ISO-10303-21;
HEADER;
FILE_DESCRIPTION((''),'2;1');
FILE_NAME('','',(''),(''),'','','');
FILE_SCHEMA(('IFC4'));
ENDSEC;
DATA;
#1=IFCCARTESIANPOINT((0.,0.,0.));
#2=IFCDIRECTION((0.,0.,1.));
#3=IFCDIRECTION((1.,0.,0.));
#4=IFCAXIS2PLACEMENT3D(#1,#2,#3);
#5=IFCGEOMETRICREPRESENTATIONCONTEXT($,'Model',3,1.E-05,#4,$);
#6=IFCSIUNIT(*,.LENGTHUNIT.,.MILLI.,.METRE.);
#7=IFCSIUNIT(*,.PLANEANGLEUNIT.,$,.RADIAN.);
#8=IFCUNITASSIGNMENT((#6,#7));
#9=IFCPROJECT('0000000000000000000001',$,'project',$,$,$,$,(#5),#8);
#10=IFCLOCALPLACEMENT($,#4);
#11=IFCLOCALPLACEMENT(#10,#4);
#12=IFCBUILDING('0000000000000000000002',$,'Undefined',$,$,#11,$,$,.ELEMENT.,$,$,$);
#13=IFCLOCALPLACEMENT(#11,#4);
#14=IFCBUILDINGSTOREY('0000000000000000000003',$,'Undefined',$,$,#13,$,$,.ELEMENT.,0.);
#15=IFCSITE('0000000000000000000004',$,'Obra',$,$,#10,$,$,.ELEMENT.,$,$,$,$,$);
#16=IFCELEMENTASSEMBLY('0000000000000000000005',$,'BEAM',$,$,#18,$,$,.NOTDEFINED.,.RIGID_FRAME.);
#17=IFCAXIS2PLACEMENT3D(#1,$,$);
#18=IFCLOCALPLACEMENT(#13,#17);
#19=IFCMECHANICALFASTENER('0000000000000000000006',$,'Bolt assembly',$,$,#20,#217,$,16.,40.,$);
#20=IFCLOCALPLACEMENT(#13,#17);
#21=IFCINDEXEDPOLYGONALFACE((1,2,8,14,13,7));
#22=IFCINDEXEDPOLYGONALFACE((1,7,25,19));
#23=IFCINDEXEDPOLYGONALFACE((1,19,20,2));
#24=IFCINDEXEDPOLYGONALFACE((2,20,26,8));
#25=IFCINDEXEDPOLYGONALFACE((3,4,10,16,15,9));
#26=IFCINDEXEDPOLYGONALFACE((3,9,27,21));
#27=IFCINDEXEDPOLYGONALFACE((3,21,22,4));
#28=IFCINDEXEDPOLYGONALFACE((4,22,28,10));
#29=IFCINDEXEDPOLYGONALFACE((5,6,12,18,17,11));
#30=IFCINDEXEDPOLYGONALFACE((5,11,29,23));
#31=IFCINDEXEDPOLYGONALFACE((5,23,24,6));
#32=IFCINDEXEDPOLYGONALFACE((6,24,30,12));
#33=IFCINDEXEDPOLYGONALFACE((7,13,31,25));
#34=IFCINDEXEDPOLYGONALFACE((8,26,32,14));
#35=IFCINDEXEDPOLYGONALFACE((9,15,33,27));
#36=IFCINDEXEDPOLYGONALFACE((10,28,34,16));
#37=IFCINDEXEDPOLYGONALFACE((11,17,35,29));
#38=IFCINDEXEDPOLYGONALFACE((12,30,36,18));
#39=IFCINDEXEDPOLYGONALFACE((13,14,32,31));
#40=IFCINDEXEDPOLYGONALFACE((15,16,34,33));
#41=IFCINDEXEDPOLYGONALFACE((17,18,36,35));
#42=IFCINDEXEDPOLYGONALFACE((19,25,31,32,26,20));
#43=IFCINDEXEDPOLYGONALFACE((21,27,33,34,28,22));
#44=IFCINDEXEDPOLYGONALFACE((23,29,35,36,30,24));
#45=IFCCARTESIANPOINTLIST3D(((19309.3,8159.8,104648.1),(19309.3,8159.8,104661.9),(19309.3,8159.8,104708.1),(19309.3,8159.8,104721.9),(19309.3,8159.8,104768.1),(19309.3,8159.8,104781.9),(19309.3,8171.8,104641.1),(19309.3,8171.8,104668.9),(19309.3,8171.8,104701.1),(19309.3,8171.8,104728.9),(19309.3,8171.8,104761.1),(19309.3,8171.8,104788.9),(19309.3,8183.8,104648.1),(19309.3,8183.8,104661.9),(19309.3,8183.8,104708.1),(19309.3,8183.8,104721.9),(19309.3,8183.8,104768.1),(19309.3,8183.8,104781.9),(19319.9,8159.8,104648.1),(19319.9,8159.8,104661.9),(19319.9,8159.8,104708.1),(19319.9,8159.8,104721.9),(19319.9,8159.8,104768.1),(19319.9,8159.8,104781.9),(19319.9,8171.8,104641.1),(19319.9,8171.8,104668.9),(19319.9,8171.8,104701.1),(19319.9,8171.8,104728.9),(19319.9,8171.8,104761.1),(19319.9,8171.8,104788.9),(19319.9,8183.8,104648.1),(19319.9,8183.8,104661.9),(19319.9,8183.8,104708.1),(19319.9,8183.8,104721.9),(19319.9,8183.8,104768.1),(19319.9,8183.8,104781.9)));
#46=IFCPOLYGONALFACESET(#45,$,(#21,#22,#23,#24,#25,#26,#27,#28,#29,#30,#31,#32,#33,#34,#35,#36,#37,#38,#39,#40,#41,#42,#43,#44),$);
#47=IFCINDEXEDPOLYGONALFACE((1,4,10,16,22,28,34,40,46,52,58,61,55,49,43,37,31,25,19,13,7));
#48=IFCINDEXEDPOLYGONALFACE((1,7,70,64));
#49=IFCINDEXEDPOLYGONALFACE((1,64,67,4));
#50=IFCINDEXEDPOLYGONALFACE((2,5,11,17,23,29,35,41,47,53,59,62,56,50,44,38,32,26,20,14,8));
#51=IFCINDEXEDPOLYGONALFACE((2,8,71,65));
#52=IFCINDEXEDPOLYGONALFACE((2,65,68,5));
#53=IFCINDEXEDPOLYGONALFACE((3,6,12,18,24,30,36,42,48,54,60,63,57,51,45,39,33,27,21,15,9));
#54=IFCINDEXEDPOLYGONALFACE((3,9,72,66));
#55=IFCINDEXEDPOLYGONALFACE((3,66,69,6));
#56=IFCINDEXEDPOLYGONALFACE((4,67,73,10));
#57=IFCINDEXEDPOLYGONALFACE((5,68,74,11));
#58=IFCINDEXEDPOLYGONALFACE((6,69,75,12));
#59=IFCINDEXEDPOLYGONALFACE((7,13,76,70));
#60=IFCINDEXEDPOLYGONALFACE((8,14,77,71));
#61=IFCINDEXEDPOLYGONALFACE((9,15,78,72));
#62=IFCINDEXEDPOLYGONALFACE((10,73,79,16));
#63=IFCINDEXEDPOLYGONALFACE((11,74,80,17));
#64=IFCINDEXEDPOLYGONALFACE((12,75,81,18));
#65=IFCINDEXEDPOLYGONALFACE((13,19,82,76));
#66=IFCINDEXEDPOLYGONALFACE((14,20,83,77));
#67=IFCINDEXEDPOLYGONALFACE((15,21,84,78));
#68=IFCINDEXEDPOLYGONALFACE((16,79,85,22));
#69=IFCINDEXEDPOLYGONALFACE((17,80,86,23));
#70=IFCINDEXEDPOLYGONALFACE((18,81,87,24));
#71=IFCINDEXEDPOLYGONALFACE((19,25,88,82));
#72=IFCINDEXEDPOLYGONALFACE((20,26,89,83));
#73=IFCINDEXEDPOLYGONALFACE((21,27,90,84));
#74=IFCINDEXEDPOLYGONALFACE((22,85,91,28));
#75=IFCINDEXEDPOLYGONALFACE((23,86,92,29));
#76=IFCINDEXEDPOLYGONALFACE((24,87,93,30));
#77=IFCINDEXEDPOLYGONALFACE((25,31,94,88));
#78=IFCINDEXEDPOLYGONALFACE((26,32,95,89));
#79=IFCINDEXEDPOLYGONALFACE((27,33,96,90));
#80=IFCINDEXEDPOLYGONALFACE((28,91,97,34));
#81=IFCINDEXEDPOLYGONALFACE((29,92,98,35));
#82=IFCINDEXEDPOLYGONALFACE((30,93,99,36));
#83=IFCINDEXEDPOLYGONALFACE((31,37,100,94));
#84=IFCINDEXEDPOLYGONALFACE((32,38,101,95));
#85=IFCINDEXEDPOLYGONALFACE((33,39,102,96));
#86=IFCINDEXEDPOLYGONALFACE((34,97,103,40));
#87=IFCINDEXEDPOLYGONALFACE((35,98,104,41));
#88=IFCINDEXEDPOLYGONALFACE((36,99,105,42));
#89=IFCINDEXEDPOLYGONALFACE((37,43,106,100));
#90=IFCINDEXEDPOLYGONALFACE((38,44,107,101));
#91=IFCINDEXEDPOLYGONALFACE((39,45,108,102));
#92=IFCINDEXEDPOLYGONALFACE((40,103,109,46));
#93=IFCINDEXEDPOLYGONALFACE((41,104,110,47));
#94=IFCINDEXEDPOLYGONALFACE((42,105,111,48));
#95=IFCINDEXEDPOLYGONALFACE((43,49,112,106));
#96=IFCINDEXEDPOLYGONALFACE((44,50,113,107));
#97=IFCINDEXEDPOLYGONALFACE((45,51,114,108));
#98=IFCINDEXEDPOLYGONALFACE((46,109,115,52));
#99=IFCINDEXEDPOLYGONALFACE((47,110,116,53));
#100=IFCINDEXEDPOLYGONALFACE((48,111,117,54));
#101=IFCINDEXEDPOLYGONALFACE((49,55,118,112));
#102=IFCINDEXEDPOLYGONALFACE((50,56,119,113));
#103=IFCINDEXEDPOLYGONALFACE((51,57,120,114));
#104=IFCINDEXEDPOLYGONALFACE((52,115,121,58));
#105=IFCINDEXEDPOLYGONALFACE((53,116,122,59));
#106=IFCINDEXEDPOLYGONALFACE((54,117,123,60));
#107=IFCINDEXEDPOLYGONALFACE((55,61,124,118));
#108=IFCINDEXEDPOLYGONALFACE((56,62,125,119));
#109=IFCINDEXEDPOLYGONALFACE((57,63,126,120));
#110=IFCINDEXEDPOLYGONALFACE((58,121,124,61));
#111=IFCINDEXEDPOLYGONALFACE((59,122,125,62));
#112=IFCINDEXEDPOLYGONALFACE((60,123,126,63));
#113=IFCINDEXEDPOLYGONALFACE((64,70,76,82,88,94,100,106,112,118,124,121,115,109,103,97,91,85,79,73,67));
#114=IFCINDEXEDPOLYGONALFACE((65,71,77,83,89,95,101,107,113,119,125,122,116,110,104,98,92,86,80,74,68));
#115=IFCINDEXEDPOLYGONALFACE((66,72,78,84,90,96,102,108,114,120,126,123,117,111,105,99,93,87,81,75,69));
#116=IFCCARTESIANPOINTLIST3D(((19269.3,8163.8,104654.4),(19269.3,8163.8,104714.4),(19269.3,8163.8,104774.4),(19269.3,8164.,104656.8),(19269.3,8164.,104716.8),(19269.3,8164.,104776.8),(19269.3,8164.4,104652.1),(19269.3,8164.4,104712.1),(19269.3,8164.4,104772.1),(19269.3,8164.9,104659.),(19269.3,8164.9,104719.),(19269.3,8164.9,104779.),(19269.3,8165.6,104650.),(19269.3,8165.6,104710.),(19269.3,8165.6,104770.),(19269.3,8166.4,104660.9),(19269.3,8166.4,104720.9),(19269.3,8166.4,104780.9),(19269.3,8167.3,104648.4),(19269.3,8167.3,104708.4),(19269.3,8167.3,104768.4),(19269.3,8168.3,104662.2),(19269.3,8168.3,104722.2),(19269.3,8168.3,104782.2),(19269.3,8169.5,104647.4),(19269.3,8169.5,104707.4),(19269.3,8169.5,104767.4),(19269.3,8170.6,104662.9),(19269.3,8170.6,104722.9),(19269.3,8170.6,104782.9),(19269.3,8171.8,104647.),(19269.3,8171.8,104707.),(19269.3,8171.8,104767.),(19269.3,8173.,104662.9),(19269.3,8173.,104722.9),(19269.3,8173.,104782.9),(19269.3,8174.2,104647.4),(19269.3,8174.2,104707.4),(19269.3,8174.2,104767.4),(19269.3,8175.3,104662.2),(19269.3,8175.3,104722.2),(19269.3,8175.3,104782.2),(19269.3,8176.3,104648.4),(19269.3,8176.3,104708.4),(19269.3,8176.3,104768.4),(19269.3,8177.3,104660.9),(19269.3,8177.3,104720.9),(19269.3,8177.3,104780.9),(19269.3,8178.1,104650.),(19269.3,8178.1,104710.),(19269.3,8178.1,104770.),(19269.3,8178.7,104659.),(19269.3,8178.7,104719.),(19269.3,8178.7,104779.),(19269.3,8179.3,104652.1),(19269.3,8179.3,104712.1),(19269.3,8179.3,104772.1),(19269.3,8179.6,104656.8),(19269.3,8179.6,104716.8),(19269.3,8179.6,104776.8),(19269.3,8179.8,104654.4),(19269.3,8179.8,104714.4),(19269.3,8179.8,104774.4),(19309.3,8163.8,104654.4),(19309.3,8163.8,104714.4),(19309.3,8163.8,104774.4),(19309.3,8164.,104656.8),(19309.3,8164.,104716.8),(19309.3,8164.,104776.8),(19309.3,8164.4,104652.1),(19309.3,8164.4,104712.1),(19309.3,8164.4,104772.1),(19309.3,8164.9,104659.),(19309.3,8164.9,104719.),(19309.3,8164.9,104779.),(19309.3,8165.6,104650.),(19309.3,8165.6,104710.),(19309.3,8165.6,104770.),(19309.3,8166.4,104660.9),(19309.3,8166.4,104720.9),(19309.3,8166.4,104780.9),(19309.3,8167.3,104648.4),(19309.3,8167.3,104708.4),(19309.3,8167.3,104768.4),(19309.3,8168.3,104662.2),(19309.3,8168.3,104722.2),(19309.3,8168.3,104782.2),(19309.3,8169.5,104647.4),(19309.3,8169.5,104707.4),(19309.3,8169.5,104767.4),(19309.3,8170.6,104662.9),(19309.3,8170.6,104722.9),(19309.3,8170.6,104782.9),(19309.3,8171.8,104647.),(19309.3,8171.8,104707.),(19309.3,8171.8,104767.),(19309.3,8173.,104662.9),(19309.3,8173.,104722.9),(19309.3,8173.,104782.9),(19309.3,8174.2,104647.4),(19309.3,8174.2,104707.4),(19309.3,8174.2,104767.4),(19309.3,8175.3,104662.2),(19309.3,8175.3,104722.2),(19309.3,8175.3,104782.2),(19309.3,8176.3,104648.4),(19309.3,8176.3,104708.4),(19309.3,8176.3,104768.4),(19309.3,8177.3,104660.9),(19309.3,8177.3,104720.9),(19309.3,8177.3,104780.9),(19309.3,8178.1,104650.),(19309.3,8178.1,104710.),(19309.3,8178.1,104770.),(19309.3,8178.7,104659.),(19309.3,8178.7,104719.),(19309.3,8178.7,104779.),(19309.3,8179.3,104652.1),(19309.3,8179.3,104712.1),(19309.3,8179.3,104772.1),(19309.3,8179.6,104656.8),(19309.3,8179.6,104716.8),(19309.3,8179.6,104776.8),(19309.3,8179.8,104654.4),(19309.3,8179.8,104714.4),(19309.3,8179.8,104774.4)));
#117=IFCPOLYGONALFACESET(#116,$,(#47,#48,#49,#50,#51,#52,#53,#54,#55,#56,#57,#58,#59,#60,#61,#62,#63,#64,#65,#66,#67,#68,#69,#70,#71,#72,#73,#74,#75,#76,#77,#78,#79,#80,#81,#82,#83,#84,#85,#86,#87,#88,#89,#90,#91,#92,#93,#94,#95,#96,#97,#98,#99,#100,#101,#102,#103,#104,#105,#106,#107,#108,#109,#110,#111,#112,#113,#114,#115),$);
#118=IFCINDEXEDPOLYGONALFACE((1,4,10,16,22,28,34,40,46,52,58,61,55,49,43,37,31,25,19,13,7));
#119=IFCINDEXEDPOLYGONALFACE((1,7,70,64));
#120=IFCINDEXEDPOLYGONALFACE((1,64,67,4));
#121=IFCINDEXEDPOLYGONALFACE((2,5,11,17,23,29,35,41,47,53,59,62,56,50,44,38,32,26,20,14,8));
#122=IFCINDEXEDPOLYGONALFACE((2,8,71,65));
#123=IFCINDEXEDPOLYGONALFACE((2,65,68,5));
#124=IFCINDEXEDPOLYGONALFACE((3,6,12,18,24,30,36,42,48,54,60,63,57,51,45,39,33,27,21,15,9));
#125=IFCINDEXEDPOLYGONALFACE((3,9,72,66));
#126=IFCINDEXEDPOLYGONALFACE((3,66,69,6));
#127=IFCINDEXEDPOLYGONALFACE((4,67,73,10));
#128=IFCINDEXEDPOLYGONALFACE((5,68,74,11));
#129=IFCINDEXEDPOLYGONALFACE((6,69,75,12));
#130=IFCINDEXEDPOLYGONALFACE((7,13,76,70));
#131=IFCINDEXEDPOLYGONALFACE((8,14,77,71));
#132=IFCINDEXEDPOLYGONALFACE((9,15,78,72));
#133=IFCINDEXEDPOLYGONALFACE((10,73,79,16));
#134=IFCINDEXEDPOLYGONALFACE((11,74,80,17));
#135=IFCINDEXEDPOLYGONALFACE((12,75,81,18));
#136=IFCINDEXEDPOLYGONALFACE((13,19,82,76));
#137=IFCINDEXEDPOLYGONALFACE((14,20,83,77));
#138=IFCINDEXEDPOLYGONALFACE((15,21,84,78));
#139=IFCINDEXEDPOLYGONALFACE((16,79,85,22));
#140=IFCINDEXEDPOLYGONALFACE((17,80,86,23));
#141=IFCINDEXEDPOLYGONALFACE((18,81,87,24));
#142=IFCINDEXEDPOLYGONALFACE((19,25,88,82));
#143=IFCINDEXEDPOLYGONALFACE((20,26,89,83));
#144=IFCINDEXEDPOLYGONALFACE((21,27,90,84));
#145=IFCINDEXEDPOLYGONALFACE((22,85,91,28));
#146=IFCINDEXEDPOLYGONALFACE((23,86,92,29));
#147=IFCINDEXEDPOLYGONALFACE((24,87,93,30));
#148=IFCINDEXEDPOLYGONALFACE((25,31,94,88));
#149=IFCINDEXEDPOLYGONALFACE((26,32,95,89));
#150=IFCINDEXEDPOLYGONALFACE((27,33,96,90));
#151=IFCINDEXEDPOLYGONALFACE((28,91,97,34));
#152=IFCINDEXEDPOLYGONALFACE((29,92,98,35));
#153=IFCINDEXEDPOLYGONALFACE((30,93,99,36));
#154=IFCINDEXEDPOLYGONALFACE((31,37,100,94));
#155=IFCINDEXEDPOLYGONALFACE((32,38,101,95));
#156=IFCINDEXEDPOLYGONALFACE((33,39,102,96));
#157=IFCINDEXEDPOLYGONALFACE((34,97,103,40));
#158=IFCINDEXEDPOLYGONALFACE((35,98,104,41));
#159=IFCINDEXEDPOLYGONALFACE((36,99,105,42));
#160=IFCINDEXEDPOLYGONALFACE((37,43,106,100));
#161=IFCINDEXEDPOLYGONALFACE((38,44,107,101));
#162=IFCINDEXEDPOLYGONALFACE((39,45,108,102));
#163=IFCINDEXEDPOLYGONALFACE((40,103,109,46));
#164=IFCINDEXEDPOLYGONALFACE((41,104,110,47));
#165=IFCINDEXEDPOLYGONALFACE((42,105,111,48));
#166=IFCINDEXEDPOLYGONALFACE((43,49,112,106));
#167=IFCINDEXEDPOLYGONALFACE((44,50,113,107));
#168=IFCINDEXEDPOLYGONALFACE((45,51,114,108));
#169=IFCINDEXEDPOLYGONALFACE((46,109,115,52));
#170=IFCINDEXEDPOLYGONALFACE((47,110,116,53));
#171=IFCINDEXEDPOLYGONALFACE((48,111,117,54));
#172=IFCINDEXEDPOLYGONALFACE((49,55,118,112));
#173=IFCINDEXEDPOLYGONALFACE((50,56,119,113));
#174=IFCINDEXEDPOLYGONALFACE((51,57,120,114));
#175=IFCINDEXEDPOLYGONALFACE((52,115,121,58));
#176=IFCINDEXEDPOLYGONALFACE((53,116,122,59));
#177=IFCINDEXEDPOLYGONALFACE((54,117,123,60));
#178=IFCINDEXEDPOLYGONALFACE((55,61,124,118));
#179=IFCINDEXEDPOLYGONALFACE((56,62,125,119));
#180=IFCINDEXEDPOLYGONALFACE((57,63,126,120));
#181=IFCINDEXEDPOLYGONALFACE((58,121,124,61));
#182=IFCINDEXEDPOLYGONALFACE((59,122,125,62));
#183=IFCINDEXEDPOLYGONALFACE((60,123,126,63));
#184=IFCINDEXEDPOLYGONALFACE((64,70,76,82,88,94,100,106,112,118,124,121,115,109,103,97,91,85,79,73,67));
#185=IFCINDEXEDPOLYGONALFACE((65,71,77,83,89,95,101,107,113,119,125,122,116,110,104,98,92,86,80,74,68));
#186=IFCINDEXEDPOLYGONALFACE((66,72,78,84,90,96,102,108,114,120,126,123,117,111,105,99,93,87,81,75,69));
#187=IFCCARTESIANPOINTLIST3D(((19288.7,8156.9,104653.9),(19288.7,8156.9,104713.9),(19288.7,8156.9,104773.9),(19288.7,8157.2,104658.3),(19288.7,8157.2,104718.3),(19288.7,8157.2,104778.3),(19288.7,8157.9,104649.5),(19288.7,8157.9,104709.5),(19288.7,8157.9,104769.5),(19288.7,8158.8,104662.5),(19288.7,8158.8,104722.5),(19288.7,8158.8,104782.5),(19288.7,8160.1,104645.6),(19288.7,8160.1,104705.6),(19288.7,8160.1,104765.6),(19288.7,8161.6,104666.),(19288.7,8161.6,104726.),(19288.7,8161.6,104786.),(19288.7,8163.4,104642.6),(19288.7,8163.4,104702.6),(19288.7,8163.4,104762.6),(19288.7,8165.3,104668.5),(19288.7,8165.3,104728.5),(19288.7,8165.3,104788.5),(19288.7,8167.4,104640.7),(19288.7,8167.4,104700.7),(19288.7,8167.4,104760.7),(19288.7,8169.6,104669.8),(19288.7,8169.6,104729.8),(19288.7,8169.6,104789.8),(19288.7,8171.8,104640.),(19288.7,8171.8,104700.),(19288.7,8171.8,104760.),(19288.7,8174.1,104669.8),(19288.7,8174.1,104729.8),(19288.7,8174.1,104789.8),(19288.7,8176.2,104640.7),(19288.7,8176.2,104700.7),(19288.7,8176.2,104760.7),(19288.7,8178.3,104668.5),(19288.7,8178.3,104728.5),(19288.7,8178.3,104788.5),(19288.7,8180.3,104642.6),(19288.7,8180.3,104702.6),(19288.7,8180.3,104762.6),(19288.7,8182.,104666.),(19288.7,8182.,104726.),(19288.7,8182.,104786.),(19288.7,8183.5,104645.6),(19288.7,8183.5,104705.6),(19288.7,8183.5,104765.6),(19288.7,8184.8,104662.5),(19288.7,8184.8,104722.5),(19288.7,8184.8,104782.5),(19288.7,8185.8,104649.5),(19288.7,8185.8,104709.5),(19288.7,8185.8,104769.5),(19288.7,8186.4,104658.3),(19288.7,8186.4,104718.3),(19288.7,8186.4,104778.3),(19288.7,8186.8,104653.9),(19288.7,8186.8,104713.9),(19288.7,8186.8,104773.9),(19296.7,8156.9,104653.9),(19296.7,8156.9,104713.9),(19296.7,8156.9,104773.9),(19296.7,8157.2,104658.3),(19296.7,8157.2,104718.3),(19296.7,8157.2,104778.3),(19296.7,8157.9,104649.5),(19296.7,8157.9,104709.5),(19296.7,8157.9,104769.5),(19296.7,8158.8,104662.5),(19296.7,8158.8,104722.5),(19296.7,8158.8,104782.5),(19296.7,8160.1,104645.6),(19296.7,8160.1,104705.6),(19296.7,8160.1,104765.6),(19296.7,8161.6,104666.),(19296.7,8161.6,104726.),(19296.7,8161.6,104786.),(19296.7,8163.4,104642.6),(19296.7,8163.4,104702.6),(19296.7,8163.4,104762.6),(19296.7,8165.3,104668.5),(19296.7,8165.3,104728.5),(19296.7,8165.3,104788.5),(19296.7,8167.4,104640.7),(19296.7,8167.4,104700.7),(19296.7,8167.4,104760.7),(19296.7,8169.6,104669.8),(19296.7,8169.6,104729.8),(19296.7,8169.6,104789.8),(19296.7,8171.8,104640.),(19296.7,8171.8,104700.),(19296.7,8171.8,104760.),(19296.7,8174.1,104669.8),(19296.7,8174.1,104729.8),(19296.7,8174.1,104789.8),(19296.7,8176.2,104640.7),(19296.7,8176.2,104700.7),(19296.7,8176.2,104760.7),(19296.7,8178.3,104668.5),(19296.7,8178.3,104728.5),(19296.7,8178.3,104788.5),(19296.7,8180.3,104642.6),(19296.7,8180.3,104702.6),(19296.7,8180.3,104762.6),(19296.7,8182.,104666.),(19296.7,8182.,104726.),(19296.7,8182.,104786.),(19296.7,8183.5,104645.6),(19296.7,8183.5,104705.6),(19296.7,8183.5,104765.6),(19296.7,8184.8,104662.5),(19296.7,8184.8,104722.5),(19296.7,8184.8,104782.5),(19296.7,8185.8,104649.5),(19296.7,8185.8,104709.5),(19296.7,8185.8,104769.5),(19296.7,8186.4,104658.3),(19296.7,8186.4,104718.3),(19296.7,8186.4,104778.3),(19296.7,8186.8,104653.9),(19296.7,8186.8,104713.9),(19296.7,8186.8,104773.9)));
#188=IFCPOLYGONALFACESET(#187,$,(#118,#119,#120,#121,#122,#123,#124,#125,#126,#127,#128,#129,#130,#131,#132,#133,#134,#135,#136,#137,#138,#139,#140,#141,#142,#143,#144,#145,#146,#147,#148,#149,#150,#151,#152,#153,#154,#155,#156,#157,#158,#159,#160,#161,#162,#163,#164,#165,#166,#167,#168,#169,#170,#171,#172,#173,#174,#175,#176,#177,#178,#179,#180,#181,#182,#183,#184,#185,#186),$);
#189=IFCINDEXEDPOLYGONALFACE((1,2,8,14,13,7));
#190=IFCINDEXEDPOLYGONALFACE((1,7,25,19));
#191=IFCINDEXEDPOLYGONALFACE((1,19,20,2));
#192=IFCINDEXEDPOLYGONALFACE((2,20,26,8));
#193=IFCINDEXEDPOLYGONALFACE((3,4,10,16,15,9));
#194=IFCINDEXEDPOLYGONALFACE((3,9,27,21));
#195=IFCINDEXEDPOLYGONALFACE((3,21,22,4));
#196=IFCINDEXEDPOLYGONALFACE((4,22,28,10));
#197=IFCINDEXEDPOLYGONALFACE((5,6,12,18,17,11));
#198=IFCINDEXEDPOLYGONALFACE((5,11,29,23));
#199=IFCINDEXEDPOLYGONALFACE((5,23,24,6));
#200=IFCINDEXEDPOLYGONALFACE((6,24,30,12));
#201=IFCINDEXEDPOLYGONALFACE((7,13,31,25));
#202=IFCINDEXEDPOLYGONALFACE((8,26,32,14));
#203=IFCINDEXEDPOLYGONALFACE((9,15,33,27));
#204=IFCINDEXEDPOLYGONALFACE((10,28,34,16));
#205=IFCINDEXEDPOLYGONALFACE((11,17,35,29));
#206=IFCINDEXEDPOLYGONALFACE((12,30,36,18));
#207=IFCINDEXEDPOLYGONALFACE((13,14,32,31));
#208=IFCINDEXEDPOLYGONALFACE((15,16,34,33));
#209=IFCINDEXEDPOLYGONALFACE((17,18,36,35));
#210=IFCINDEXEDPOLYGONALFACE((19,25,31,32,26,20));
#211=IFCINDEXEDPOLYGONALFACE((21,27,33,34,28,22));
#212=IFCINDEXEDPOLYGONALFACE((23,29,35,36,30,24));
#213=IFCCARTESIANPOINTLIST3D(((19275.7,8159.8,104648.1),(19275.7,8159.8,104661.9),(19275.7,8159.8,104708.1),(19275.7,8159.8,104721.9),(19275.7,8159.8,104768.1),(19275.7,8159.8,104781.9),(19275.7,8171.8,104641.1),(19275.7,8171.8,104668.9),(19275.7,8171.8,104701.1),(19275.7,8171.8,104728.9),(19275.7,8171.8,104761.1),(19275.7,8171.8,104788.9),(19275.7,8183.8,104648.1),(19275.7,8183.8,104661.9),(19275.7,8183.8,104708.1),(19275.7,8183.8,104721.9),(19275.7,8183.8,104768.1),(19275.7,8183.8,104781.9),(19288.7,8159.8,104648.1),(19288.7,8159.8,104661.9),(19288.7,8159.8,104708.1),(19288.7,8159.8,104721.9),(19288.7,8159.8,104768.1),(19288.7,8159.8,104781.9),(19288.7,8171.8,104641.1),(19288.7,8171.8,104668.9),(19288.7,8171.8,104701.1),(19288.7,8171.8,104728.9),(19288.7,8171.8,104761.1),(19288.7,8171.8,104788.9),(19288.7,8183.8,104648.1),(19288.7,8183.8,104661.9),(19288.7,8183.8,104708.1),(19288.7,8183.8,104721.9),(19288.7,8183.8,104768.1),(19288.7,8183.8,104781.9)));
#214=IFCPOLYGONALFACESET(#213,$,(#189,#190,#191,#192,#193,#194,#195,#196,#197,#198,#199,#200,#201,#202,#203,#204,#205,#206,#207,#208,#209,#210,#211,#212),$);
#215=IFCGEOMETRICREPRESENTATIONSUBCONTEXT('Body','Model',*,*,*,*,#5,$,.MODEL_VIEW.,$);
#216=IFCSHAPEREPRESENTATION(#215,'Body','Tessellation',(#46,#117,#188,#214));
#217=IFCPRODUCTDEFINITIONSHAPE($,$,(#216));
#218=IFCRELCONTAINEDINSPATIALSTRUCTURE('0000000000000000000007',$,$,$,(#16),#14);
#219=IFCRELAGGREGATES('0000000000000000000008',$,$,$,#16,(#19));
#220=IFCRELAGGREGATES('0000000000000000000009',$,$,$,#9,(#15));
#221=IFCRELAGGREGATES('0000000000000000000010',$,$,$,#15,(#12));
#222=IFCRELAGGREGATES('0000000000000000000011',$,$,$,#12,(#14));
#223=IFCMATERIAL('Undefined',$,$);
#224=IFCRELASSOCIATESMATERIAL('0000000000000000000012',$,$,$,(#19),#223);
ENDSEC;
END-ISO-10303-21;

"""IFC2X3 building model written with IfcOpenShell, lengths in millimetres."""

from ifc_helpers import new_model, si_unit, frame, origin_with_axes, origin_2d_with_axis, place, context, subcontext, project, spatial, polyline, circle, outline, extrude, source, transform, mapped, material, element, aggregate, save


model = new_model("IFC2X3")

# Units and contexts
model_context = context("Model", 3, precision=1e-05, world=origin_with_axes())
body_context = subcontext(model_context, "Body", "Model", "MODEL_VIEW")
ifc_project = project(units=[si_unit("LENGTHUNIT", "METRE", prefix="MILLI"), si_unit("PLANEANGLEUNIT", "RADIAN")], contexts=[model_context])

# Site, building, storey
site_placement = place(None, origin_with_axes())
site = spatial("IfcSite", under=ifc_project, at=site_placement, Name="Obra", CompositionType="ELEMENT")
building_placement = place(site_placement, origin_with_axes())
building = spatial("IfcBuilding", under=site, at=building_placement, Name="Undefined", CompositionType="ELEMENT")
storey_placement = place(building_placement, origin_with_axes())
storey = spatial("IfcBuildingStorey", under=building, at=storey_placement, Name="Undefined", CompositionType="ELEMENT", Elevation=0.0)

# Shared definitions
ifc_material_1 = material(Name="Undefined")

# Element assembly, mechanical fastener
shared_shape_1 = source(origin_with_axes(), body_context, "Body", "SweptSolid", [
    extrude(outline(polyline([(13.9, 0.0), (6.9, 12.0), (-6.9, 12.0), (-13.9, 0.0), (-6.9, -12.0), (6.9, -12.0), (13.9, 0.0)])), frame((0.0, -19.9, 0.0), z_axis=(0.0, 1.0, 0.0), x_axis=(1.0, 0.0, 0.0)), (0.0, 0.0, 1.0), 10.6),
    extrude(circle(Radius=8.0, at=origin_2d_with_axis()), frame((0.0, -9.3, 0.0), z_axis=(0.0, 1.0, 0.0), x_axis=(1.0, 0.0, 0.0)), (0.0, 0.0, 1.0), 40.0),
    extrude(circle(Radius=15.0, at=origin_2d_with_axis()), frame((0.0, 3.3, 0.0), z_axis=(0.0, 1.0, 0.0), x_axis=(1.0, 0.0, 0.0)), (0.0, 0.0, 1.0), 8.0),
    extrude(outline(polyline([(13.9, 0.0), (6.9, 12.0), (-6.9, 12.0), (-13.9, 0.0), (-6.9, -12.0), (6.9, -12.0), (13.9, 0.0)])), frame((0.0, 11.3, 0.0), z_axis=(0.0, 1.0, 0.0), x_axis=(1.0, 0.0, 0.0)), (0.0, 0.0, 1.0), 13.0),
])
assembly_1_placement = place(storey_placement, origin_with_axes())
assembly_1 = element("IfcElementAssembly", 1, at=assembly_1_placement, inside=storey, Name="BEAM", AssemblyPlace="NOTDEFINED", PredefinedType="RIGID_FRAME")
mechanical_fastener_1_placement = place(assembly_1_placement, frame((19300.0, 8136.8, 104850.0), z_axis=(0.0, 1.0, 0.0), x_axis=(0.0, 0.0, -1.0)))
mechanical_fastener_1 = element("IfcMechanicalFastener", 2, at=mechanical_fastener_1_placement, material=ifc_material_1, Name="Bolt assembly", NominalDiameter=16.0, NominalLength=40.0, context=body_context, shape_type="MappedRepresentation", body=[
    mapped(shared_shape_1, transform((75.0, 0.0, 35.0))),
    mapped(shared_shape_1, transform((135.0, 0.0, 35.0))),
    mapped(shared_shape_1, transform((195.0, 0.0, 35.0))),
])
aggregate(assembly_1, [mechanical_fastener_1])

save(model, "model.ifc")
